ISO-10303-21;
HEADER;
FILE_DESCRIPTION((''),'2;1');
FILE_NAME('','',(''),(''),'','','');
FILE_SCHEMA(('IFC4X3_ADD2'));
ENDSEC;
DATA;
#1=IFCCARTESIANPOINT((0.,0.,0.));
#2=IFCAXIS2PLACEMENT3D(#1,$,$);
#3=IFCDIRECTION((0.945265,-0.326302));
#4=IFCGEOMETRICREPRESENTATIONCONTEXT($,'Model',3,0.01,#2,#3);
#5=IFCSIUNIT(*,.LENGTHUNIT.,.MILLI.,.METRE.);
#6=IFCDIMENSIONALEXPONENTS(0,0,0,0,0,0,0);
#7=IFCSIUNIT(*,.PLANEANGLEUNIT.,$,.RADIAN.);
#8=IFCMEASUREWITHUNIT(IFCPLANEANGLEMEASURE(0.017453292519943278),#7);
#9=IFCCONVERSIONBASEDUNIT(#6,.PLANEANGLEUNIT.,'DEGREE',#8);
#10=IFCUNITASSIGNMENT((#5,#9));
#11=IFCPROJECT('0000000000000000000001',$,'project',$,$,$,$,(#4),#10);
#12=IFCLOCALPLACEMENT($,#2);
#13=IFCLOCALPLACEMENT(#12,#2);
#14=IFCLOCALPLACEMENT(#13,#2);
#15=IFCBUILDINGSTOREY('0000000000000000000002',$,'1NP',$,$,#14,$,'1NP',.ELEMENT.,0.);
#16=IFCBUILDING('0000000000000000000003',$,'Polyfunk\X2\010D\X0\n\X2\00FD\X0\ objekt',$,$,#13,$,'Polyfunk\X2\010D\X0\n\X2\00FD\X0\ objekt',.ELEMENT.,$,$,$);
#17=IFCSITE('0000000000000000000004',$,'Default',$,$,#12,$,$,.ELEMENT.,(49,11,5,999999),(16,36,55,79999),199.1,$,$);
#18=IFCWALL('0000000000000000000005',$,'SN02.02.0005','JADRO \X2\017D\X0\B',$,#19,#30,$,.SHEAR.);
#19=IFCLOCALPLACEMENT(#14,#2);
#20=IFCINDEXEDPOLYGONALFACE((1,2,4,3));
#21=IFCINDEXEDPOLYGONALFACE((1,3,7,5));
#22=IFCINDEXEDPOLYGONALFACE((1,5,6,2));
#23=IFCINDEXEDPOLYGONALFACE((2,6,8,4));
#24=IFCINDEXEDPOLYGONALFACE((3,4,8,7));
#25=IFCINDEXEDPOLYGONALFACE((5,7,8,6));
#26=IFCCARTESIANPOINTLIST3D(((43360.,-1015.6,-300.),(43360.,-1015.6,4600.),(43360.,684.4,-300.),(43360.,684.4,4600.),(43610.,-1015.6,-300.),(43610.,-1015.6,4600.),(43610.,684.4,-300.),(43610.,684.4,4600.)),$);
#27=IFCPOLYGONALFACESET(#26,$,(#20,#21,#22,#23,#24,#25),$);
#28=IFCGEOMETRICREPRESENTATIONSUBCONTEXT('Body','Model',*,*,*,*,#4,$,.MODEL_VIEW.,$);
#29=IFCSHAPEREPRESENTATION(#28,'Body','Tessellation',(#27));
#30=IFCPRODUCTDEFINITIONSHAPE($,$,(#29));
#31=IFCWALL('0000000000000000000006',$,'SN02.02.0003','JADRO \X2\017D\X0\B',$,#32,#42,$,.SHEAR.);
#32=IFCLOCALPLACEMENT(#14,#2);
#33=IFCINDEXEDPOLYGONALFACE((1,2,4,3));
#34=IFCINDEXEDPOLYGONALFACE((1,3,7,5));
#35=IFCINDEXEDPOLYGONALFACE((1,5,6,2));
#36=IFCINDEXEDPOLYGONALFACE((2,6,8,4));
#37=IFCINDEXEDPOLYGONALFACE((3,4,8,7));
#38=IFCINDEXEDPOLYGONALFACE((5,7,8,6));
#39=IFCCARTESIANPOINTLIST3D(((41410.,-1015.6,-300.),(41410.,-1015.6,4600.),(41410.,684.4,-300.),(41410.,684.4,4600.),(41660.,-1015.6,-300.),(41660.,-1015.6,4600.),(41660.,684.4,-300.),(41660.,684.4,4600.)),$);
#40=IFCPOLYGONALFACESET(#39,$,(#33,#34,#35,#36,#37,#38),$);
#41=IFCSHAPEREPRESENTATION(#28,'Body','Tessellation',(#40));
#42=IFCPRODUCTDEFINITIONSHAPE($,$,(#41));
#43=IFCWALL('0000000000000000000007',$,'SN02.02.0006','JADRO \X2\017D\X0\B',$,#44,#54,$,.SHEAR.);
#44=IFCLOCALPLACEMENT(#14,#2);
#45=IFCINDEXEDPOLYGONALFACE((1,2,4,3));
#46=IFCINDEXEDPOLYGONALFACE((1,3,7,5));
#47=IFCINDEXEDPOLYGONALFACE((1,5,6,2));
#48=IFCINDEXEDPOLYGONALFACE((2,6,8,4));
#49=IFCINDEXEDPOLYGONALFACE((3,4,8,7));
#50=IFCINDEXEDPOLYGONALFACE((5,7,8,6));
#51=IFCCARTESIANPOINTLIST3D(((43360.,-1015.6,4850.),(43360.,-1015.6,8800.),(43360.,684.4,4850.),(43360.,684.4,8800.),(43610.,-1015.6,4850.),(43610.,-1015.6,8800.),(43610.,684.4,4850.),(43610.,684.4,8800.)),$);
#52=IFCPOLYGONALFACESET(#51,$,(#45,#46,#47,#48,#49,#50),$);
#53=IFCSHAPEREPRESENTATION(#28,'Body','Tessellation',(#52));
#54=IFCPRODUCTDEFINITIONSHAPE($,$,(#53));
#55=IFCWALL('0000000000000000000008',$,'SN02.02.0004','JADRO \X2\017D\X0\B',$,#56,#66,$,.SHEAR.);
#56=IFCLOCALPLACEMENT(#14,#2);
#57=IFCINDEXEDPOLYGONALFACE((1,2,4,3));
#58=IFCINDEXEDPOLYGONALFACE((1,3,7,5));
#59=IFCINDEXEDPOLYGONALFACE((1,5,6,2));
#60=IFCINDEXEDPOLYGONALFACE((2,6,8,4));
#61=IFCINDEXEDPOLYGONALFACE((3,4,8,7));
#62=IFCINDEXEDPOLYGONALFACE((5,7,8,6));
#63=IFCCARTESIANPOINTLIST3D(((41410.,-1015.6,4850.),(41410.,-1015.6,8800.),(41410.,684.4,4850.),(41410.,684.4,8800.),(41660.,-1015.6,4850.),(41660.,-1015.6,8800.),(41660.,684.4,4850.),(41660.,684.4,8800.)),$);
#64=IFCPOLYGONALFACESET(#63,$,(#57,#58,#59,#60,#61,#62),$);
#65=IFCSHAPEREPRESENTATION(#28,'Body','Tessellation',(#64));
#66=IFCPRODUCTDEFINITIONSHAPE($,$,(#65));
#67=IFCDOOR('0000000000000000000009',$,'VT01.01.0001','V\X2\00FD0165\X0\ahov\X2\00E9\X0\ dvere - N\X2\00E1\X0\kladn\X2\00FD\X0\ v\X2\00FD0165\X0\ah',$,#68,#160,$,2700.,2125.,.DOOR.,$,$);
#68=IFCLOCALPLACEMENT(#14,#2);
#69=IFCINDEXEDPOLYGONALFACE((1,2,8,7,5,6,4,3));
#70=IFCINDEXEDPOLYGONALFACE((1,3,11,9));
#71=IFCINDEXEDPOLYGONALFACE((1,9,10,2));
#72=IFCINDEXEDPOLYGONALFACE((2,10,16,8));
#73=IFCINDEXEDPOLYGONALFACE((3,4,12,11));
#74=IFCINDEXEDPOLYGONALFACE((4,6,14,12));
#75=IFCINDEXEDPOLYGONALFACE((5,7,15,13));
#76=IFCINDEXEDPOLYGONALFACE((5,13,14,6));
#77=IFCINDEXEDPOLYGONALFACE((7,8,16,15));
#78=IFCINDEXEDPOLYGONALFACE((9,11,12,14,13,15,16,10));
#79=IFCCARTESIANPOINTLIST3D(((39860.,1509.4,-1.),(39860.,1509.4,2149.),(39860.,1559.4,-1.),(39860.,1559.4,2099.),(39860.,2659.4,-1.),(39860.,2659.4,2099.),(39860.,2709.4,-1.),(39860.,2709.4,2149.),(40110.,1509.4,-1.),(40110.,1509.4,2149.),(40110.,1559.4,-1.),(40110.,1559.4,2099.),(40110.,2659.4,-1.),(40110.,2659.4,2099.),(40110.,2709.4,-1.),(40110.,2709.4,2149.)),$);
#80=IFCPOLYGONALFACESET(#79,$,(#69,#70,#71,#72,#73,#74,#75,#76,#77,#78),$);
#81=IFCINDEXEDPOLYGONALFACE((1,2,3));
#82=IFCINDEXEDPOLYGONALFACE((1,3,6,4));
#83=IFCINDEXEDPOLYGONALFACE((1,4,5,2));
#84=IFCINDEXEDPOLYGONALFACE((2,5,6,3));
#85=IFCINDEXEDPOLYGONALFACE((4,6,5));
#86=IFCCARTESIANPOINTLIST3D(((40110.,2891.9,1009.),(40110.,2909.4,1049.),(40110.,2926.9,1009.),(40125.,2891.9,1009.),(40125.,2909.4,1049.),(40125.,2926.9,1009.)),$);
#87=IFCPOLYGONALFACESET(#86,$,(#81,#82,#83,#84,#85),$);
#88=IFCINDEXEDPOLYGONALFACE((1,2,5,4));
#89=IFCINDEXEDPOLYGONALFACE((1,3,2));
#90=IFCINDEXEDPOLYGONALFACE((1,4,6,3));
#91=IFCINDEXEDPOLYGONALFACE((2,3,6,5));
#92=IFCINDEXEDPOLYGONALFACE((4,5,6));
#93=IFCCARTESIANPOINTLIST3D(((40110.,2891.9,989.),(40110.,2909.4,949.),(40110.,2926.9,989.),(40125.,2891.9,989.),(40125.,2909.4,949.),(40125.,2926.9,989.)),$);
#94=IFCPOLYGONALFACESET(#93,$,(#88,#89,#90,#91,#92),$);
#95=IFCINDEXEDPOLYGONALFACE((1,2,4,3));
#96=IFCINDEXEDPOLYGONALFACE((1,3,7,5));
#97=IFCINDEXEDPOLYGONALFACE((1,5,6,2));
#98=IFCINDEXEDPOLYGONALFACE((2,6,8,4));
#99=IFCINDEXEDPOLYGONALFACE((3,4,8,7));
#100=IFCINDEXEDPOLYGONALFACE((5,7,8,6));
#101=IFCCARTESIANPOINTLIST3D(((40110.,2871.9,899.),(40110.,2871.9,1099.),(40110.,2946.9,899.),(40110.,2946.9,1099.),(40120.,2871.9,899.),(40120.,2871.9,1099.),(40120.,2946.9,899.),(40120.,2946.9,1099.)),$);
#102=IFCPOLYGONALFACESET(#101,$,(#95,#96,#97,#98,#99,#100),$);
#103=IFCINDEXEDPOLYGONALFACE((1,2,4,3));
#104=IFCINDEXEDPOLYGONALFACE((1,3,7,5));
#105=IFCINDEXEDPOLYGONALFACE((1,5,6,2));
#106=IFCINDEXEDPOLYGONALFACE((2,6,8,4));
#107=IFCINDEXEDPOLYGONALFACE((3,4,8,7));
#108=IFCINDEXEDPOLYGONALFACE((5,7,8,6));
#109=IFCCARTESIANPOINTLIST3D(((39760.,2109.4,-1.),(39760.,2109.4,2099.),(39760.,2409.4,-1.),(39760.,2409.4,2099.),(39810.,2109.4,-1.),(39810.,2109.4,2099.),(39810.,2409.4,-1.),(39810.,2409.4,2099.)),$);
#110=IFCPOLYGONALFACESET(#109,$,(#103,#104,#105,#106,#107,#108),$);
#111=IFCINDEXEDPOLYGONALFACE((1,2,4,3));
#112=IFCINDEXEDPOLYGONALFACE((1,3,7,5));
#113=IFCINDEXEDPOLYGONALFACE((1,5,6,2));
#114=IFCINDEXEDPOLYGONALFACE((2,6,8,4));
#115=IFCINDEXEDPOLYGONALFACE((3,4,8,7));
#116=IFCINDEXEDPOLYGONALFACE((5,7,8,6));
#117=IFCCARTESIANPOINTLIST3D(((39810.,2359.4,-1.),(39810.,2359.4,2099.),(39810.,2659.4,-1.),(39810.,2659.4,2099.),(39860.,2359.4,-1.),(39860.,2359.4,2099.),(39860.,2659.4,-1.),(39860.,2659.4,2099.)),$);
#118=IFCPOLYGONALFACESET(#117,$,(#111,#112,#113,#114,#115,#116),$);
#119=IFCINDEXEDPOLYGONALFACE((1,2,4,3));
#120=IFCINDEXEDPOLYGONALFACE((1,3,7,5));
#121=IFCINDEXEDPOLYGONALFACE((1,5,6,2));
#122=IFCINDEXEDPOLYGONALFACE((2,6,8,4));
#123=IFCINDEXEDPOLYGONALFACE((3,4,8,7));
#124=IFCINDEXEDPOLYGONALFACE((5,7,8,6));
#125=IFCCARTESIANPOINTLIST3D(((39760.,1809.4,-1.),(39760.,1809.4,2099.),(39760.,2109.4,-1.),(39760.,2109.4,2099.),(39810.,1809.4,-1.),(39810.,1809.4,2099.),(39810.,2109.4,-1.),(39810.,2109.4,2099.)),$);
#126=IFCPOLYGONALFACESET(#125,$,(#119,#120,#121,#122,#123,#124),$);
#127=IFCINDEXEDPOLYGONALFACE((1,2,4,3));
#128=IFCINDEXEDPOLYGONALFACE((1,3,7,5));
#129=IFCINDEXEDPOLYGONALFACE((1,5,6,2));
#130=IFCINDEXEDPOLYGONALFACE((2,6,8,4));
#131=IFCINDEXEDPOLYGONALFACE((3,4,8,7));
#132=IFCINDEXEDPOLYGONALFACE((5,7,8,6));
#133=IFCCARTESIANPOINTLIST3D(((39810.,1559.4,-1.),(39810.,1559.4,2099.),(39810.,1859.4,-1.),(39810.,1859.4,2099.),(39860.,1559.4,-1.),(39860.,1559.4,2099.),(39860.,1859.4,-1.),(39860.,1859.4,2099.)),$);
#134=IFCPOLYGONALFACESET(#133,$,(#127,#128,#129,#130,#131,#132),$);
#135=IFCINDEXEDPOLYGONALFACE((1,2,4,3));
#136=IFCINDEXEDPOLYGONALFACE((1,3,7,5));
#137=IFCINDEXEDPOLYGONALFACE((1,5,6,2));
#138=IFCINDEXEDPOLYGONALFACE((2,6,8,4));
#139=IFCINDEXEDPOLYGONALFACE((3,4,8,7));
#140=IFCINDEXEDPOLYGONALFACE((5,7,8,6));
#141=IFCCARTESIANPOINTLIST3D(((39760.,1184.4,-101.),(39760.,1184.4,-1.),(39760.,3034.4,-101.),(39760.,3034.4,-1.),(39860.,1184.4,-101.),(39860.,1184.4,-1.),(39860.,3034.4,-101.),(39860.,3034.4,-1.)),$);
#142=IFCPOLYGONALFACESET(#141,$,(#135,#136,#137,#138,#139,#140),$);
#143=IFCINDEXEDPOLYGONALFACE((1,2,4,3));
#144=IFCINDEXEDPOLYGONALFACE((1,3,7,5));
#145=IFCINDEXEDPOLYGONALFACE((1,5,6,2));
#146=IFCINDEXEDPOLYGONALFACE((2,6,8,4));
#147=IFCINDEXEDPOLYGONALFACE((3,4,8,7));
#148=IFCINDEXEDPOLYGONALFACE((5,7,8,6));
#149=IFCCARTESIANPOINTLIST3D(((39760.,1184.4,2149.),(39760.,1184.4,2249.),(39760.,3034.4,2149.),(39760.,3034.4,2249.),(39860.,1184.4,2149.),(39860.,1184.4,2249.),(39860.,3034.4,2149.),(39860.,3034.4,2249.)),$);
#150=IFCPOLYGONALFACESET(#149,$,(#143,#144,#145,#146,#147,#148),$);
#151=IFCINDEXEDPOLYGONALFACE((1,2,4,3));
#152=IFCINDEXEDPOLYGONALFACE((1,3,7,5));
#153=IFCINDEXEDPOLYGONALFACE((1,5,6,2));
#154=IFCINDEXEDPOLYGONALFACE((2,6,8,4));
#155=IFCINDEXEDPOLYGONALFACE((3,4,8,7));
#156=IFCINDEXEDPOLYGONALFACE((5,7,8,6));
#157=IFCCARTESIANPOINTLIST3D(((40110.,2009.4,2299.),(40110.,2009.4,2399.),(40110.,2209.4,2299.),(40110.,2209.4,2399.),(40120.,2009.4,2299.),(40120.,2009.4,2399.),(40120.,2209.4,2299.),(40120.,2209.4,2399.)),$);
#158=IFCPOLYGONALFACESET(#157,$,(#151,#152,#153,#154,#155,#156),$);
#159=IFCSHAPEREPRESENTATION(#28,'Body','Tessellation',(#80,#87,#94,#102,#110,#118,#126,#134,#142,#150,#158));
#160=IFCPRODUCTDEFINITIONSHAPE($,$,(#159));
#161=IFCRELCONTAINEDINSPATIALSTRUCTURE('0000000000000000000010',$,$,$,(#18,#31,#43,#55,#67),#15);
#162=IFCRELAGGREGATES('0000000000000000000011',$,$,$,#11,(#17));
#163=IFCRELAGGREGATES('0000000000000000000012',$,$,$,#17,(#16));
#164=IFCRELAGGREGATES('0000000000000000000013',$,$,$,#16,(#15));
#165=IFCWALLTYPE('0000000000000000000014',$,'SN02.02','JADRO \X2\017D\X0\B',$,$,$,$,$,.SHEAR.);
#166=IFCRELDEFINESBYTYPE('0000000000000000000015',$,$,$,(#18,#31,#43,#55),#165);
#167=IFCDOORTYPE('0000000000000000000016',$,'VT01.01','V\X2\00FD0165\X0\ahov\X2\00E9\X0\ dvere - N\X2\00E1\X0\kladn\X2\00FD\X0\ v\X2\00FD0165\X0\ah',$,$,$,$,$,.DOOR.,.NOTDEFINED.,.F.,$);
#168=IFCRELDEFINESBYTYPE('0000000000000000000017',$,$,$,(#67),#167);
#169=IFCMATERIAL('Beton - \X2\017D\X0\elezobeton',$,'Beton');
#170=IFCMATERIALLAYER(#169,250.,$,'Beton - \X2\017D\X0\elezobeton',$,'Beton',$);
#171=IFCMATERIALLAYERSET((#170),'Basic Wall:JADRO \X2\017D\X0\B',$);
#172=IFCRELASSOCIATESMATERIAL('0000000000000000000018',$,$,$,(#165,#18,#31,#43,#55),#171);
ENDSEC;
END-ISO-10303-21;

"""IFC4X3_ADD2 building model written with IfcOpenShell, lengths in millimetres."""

from ifc_helpers import new_model, entity, si_unit, converted_unit, direction, frame, frame_2d, origin, origin_2d_with_axis, place, context, subcontext, project, spatial, polyline, rectangle, outline, extrude, clip, bounded_halfspace, source, transform, mapped, material, layer, layer_set, type_object, type_shapes, element, save


model = new_model("IFC4X3_ADD2")

# Units and contexts
model_context = context("Model", 3, precision=0.01, world=origin(), true_north=direction((0.945265, -0.326302)))
body_context = subcontext(model_context, "Body", "Model", "MODEL_VIEW")
ifc_project = project(units=[si_unit("LENGTHUNIT", "METRE", prefix="MILLI"), converted_unit("PLANEANGLEUNIT", "DEGREE", entity("IfcPlaneAngleMeasure", 0.017453292519943278), si_unit("PLANEANGLEUNIT", "RADIAN"), dimensions=[0, 0, 0, 0, 0, 0, 0])], contexts=[model_context])

# Site, building, storey
site_placement = place(None, origin())
site = spatial("IfcSite", under=ifc_project, at=site_placement, Name="Default", CompositionType="ELEMENT", RefLatitude=(49, 11, 5, 999999), RefLongitude=(16, 36, 55, 79999), RefElevation=199.1)
building_placement = place(site_placement, origin())
building = spatial("IfcBuilding", under=site, at=building_placement, Name="Polyfunkčný objekt", LongName="Polyfunkčný objekt", CompositionType="ELEMENT")
storey_placement = place(building_placement, origin())
storey = spatial("IfcBuildingStorey", under=building, at=storey_placement, Name="1NP", LongName="1NP", CompositionType="ELEMENT", Elevation=0.0)

# Shared definitions
ifc_material_1 = material(Name="Beton - Železobeton", Category="Beton")

# Walls
ifc_layer_1 = layer(ifc_material_1, 250.0, Name="Beton - Železobeton", Category="Beton")
ifc_layer_set_1 = layer_set([ifc_layer_1], Name="Basic Wall:JADRO ŽB")
wall_type = type_object("IfcWallType", Name="SN02.02", Description="JADRO ŽB", PredefinedType="SHEAR", material=ifc_layer_set_1)
wall_1_placement = place(storey_placement, frame((43485.0, 684.4, -300.0), z_axis=(0.0, 0.0, 1.0), x_axis=(0.0, -1.0, 0.0)))
element("IfcWall", 1, at=wall_1_placement, inside=storey, type_object=wall_type, material=ifc_layer_set_1, Name="SN02.02.0005", Description="JADRO ŽB", PredefinedType="SHEAR", context=body_context, shape_type="Clipping", body=[
    clip(clip(extrude(rectangle(XDim=1700.0, YDim=250.0, at=frame_2d((850.0, 0.0), x_axis=(-1.0, 0.0))), origin(), (0.0, 0.0, 1.0), 4900.0), bounded_halfspace(frame((0.0, -125.0, 4900.0), z_axis=(0.0, 0.0, -1.0), x_axis=(0.0, 1.0, 0.0)), True, frame((0.0, -125.0, 4900.0)), polyline([(0.0, 0.0), (1700.0, 0.0), (1700.0, 250.0), (0.0, 250.0), (0.0, 0.0)]))), bounded_halfspace(frame((1700.0, -125.0, 0.0), z_axis=(0.0, 0.0, 1.0), x_axis=(-1.0, 0.0, 0.0)), True, frame((1700.0, -125.0, 0.0)), polyline([(0.0, 0.0), (0.0, 250.0), (-1700.0, 250.0), (-1700.0, 0.0), (0.0, 0.0)]))),
])
wall_2_placement = place(storey_placement, frame((41535.0, 684.4, -300.0), z_axis=(0.0, 0.0, 1.0), x_axis=(0.0, -1.0, 0.0)))
element("IfcWall", 2, at=wall_2_placement, inside=storey, type_object=wall_type, material=ifc_layer_set_1, Name="SN02.02.0003", Description="JADRO ŽB", PredefinedType="SHEAR", context=body_context, shape_type="Clipping", body=[
    clip(clip(extrude(rectangle(XDim=1700.0, YDim=250.0, at=frame_2d((850.0, 0.0), x_axis=(-1.0, 0.0))), origin(), (0.0, 0.0, 1.0), 4900.0), bounded_halfspace(frame((0.0, -125.0, 4900.0), z_axis=(0.0, 0.0, -1.0), x_axis=(0.0, 1.0, 0.0)), True, frame((0.0, -125.0, 4900.0)), polyline([(0.0, 0.0), (1700.0, 0.0), (1700.0, 250.0), (0.0, 250.0), (0.0, 0.0)]))), bounded_halfspace(frame((1700.0, -125.0, 0.0), z_axis=(0.0, 0.0, 1.0), x_axis=(-1.0, 0.0, 0.0)), True, frame((1700.0, -125.0, 0.0)), polyline([(0.0, 0.0), (0.0, 250.0), (-1700.0, 250.0), (-1700.0, 0.0), (0.0, 0.0)]))),
])
wall_3_placement = place(storey_placement, frame((43485.0, 684.4, 4850.0), z_axis=(0.0, 0.0, 1.0), x_axis=(0.0, -1.0, 0.0)))
element("IfcWall", 3, at=wall_3_placement, inside=storey, type_object=wall_type, material=ifc_layer_set_1, Name="SN02.02.0006", Description="JADRO ŽB", PredefinedType="SHEAR", context=body_context, shape_type="Clipping", body=[
    clip(clip(extrude(rectangle(XDim=1700.0, YDim=250.0, at=frame_2d((850.0, 0.0), x_axis=(-1.0, 0.0))), origin(), (0.0, 0.0, 1.0), 3950.0), bounded_halfspace(frame((1700.0, -125.0, 0.0), z_axis=(0.0, 0.0, 1.0), x_axis=(0.0, -1.0, 0.0)), True, frame((1700.0, -125.0, 0.0)), polyline([(0.0, 0.0), (0.0, 250.0), (-1700.0, 250.0), (-1700.0, 0.0), (0.0, 0.0)]))), bounded_halfspace(frame((0.0, -125.0, 3950.0), z_axis=(0.0, 0.0, -1.0), x_axis=(0.0, 1.0, 0.0)), True, frame((0.0, -125.0, 3950.0)), polyline([(0.0, 0.0), (1700.0, 0.0), (1700.0, 250.0), (0.0, 250.0), (0.0, 0.0)]))),
])
wall_4_placement = place(storey_placement, frame((41535.0, 684.4, 4850.0), z_axis=(0.0, 0.0, 1.0), x_axis=(0.0, -1.0, 0.0)))
element("IfcWall", 4, at=wall_4_placement, inside=storey, type_object=wall_type, material=ifc_layer_set_1, Name="SN02.02.0004", Description="JADRO ŽB", PredefinedType="SHEAR", context=body_context, shape_type="Clipping", body=[
    clip(clip(extrude(rectangle(XDim=1700.0, YDim=250.0, at=frame_2d((850.0, 0.0), x_axis=(-1.0, 0.0))), origin(), (0.0, 0.0, 1.0), 3950.0), bounded_halfspace(frame((1700.0, -125.0, 0.0), z_axis=(0.0, 0.0, 1.0), x_axis=(0.0, -1.0, 0.0)), True, frame((1700.0, -125.0, 0.0)), polyline([(0.0, 0.0), (0.0, 250.0), (-1700.0, 250.0), (-1700.0, 0.0), (0.0, 0.0)]))), bounded_halfspace(frame((0.0, -125.0, 3950.0), z_axis=(0.0, 0.0, -1.0), x_axis=(0.0, 1.0, 0.0)), True, frame((0.0, -125.0, 3950.0)), polyline([(0.0, 0.0), (1700.0, 0.0), (1700.0, 250.0), (0.0, 250.0), (0.0, 0.0)]))),
])

# Door
door_type_1 = type_object("IfcDoorType", Name="VT01.01", Description="Výťahové dvere - Nákladný výťah", OperationType="NOTDEFINED", ParameterTakesPrecedence=False, PredefinedType="DOOR")
shared_shape_1 = source(origin(), body_context, "Body", "SweptSolid", [
    extrude(outline(polyline([(-1087.5, -600.0), (1062.5, -600.0), (1062.5, -550.0), (-1037.5, -550.0), (-1037.5, 550.0), (1062.5, 550.0), (1062.5, 600.0), (-1087.5, 600.0), (-1087.5, -600.0)])), frame((600.0, 0.0, 1062.5), z_axis=(0.0, 1.0, 0.0), x_axis=(0.0, 0.0, -1.0)), (0.0, 0.0, 1.0), 250.0),
    extrude(outline(polyline([(-24.4, -10.7), (19.2, -10.7), (5.2, 21.4), (-24.4, -10.7)])), frame((1400.0, -15.0, 1023.3), z_axis=(0.0, 1.0, 0.0), x_axis=(0.400819, 0.0, -0.916157)), (0.0, 0.0, 1.0), 15.0),
    extrude(outline(polyline([(-24.4, -10.7), (19.2, -10.7), (5.2, 21.4), (-24.4, -10.7)])), frame((1400.0, -15.0, 976.7), z_axis=(0.0, 1.0, 0.0), x_axis=(-0.400819, 0.0, 0.916157)), (0.0, 0.0, 1.0), 15.0),
    extrude(rectangle(XDim=10.0, YDim=75.0, at=frame_2d((0.0, 0.0), x_axis=(1.0, 0.0))), frame((1400.0, -5.0, 900.0), z_axis=(0.0, 0.0, 1.0), x_axis=(0.0, 1.0, 0.0)), (0.0, 0.0, 1.0), 200.0),
    extrude(rectangle(XDim=50.0, YDim=300.0, at=origin_2d_with_axis()), frame((750.0, 325.0, 0.0), z_axis=(0.0, 0.0, 1.0), x_axis=(0.0, -1.0, 0.0)), (0.0, 0.0, 1.0), 2100.0),
    extrude(rectangle(XDim=50.0, YDim=300.0, at=frame_2d((0.0, 0.0), x_axis=(1.0, 0.0))), frame((1000.0, 275.0, 0.0), z_axis=(0.0, 0.0, 1.0), x_axis=(0.0, -1.0, 0.0)), (0.0, 0.0, 1.0), 2100.0),
    extrude(rectangle(XDim=300.0, YDim=50.0, at=frame_2d((0.0, 0.0), x_axis=(1.0, 0.0))), frame((450.0, 325.0, 0.0), z_axis=(0.0, 0.0, 1.0), x_axis=(-1.0, 0.0, 0.0)), (0.0, 0.0, 1.0), 2100.0),
    extrude(rectangle(XDim=300.0, YDim=50.0, at=frame_2d((0.0, 0.0), x_axis=(1.0, 0.0))), frame((200.0, 275.0, 0.0), z_axis=(0.0, 0.0, 1.0), x_axis=(-1.0, 0.0, 0.0)), (0.0, 0.0, 1.0), 2100.0),
    extrude(rectangle(XDim=1850.0, YDim=100.0, at=frame_2d((0.0, 0.0), x_axis=(1.0, 0.0))), frame((600.0, 300.0, -100.0), z_axis=(0.0, 0.0, 1.0), x_axis=(-1.0, 0.0, 0.0)), (0.0, 0.0, 1.0), 100.0),
    extrude(rectangle(XDim=1850.0, YDim=100.0, at=frame_2d((0.0, 0.0), x_axis=(1.0, 0.0))), frame((600.0, 300.0, 2150.0), z_axis=(0.0, 0.0, 1.0), x_axis=(-1.0, 0.0, 0.0)), (0.0, 0.0, 1.0), 100.0),
    extrude(rectangle(XDim=10.0, YDim=200.0, at=frame_2d((0.0, 0.0), x_axis=(1.0, 0.0))), frame((600.0, -5.0, 2300.0), z_axis=(0.0, 0.0, 1.0), x_axis=(0.0, 1.0, 0.0)), (0.0, 0.0, 1.0), 100.0),
])
type_shapes(door_type_1, [shared_shape_1])
door_1_placement = place(storey_placement, frame((40110.0, 1509.4, -1.0), z_axis=(0.0, 0.0, 1.0), x_axis=(0.0, 1.0, 0.0)))
element("IfcDoor", 5, at=door_1_placement, inside=storey, type_object=door_type_1, Name="VT01.01.0001", Description="Výťahové dvere - Nákladný výťah", OverallHeight=2700.0, OverallWidth=2125.0, PredefinedType="DOOR", context=body_context, shape_type="MappedRepresentation", body=[
    mapped(shared_shape_1, transform((0.0, 0.0, 0.0), scale=1.0)),
])

save(model, "model.ifc")
